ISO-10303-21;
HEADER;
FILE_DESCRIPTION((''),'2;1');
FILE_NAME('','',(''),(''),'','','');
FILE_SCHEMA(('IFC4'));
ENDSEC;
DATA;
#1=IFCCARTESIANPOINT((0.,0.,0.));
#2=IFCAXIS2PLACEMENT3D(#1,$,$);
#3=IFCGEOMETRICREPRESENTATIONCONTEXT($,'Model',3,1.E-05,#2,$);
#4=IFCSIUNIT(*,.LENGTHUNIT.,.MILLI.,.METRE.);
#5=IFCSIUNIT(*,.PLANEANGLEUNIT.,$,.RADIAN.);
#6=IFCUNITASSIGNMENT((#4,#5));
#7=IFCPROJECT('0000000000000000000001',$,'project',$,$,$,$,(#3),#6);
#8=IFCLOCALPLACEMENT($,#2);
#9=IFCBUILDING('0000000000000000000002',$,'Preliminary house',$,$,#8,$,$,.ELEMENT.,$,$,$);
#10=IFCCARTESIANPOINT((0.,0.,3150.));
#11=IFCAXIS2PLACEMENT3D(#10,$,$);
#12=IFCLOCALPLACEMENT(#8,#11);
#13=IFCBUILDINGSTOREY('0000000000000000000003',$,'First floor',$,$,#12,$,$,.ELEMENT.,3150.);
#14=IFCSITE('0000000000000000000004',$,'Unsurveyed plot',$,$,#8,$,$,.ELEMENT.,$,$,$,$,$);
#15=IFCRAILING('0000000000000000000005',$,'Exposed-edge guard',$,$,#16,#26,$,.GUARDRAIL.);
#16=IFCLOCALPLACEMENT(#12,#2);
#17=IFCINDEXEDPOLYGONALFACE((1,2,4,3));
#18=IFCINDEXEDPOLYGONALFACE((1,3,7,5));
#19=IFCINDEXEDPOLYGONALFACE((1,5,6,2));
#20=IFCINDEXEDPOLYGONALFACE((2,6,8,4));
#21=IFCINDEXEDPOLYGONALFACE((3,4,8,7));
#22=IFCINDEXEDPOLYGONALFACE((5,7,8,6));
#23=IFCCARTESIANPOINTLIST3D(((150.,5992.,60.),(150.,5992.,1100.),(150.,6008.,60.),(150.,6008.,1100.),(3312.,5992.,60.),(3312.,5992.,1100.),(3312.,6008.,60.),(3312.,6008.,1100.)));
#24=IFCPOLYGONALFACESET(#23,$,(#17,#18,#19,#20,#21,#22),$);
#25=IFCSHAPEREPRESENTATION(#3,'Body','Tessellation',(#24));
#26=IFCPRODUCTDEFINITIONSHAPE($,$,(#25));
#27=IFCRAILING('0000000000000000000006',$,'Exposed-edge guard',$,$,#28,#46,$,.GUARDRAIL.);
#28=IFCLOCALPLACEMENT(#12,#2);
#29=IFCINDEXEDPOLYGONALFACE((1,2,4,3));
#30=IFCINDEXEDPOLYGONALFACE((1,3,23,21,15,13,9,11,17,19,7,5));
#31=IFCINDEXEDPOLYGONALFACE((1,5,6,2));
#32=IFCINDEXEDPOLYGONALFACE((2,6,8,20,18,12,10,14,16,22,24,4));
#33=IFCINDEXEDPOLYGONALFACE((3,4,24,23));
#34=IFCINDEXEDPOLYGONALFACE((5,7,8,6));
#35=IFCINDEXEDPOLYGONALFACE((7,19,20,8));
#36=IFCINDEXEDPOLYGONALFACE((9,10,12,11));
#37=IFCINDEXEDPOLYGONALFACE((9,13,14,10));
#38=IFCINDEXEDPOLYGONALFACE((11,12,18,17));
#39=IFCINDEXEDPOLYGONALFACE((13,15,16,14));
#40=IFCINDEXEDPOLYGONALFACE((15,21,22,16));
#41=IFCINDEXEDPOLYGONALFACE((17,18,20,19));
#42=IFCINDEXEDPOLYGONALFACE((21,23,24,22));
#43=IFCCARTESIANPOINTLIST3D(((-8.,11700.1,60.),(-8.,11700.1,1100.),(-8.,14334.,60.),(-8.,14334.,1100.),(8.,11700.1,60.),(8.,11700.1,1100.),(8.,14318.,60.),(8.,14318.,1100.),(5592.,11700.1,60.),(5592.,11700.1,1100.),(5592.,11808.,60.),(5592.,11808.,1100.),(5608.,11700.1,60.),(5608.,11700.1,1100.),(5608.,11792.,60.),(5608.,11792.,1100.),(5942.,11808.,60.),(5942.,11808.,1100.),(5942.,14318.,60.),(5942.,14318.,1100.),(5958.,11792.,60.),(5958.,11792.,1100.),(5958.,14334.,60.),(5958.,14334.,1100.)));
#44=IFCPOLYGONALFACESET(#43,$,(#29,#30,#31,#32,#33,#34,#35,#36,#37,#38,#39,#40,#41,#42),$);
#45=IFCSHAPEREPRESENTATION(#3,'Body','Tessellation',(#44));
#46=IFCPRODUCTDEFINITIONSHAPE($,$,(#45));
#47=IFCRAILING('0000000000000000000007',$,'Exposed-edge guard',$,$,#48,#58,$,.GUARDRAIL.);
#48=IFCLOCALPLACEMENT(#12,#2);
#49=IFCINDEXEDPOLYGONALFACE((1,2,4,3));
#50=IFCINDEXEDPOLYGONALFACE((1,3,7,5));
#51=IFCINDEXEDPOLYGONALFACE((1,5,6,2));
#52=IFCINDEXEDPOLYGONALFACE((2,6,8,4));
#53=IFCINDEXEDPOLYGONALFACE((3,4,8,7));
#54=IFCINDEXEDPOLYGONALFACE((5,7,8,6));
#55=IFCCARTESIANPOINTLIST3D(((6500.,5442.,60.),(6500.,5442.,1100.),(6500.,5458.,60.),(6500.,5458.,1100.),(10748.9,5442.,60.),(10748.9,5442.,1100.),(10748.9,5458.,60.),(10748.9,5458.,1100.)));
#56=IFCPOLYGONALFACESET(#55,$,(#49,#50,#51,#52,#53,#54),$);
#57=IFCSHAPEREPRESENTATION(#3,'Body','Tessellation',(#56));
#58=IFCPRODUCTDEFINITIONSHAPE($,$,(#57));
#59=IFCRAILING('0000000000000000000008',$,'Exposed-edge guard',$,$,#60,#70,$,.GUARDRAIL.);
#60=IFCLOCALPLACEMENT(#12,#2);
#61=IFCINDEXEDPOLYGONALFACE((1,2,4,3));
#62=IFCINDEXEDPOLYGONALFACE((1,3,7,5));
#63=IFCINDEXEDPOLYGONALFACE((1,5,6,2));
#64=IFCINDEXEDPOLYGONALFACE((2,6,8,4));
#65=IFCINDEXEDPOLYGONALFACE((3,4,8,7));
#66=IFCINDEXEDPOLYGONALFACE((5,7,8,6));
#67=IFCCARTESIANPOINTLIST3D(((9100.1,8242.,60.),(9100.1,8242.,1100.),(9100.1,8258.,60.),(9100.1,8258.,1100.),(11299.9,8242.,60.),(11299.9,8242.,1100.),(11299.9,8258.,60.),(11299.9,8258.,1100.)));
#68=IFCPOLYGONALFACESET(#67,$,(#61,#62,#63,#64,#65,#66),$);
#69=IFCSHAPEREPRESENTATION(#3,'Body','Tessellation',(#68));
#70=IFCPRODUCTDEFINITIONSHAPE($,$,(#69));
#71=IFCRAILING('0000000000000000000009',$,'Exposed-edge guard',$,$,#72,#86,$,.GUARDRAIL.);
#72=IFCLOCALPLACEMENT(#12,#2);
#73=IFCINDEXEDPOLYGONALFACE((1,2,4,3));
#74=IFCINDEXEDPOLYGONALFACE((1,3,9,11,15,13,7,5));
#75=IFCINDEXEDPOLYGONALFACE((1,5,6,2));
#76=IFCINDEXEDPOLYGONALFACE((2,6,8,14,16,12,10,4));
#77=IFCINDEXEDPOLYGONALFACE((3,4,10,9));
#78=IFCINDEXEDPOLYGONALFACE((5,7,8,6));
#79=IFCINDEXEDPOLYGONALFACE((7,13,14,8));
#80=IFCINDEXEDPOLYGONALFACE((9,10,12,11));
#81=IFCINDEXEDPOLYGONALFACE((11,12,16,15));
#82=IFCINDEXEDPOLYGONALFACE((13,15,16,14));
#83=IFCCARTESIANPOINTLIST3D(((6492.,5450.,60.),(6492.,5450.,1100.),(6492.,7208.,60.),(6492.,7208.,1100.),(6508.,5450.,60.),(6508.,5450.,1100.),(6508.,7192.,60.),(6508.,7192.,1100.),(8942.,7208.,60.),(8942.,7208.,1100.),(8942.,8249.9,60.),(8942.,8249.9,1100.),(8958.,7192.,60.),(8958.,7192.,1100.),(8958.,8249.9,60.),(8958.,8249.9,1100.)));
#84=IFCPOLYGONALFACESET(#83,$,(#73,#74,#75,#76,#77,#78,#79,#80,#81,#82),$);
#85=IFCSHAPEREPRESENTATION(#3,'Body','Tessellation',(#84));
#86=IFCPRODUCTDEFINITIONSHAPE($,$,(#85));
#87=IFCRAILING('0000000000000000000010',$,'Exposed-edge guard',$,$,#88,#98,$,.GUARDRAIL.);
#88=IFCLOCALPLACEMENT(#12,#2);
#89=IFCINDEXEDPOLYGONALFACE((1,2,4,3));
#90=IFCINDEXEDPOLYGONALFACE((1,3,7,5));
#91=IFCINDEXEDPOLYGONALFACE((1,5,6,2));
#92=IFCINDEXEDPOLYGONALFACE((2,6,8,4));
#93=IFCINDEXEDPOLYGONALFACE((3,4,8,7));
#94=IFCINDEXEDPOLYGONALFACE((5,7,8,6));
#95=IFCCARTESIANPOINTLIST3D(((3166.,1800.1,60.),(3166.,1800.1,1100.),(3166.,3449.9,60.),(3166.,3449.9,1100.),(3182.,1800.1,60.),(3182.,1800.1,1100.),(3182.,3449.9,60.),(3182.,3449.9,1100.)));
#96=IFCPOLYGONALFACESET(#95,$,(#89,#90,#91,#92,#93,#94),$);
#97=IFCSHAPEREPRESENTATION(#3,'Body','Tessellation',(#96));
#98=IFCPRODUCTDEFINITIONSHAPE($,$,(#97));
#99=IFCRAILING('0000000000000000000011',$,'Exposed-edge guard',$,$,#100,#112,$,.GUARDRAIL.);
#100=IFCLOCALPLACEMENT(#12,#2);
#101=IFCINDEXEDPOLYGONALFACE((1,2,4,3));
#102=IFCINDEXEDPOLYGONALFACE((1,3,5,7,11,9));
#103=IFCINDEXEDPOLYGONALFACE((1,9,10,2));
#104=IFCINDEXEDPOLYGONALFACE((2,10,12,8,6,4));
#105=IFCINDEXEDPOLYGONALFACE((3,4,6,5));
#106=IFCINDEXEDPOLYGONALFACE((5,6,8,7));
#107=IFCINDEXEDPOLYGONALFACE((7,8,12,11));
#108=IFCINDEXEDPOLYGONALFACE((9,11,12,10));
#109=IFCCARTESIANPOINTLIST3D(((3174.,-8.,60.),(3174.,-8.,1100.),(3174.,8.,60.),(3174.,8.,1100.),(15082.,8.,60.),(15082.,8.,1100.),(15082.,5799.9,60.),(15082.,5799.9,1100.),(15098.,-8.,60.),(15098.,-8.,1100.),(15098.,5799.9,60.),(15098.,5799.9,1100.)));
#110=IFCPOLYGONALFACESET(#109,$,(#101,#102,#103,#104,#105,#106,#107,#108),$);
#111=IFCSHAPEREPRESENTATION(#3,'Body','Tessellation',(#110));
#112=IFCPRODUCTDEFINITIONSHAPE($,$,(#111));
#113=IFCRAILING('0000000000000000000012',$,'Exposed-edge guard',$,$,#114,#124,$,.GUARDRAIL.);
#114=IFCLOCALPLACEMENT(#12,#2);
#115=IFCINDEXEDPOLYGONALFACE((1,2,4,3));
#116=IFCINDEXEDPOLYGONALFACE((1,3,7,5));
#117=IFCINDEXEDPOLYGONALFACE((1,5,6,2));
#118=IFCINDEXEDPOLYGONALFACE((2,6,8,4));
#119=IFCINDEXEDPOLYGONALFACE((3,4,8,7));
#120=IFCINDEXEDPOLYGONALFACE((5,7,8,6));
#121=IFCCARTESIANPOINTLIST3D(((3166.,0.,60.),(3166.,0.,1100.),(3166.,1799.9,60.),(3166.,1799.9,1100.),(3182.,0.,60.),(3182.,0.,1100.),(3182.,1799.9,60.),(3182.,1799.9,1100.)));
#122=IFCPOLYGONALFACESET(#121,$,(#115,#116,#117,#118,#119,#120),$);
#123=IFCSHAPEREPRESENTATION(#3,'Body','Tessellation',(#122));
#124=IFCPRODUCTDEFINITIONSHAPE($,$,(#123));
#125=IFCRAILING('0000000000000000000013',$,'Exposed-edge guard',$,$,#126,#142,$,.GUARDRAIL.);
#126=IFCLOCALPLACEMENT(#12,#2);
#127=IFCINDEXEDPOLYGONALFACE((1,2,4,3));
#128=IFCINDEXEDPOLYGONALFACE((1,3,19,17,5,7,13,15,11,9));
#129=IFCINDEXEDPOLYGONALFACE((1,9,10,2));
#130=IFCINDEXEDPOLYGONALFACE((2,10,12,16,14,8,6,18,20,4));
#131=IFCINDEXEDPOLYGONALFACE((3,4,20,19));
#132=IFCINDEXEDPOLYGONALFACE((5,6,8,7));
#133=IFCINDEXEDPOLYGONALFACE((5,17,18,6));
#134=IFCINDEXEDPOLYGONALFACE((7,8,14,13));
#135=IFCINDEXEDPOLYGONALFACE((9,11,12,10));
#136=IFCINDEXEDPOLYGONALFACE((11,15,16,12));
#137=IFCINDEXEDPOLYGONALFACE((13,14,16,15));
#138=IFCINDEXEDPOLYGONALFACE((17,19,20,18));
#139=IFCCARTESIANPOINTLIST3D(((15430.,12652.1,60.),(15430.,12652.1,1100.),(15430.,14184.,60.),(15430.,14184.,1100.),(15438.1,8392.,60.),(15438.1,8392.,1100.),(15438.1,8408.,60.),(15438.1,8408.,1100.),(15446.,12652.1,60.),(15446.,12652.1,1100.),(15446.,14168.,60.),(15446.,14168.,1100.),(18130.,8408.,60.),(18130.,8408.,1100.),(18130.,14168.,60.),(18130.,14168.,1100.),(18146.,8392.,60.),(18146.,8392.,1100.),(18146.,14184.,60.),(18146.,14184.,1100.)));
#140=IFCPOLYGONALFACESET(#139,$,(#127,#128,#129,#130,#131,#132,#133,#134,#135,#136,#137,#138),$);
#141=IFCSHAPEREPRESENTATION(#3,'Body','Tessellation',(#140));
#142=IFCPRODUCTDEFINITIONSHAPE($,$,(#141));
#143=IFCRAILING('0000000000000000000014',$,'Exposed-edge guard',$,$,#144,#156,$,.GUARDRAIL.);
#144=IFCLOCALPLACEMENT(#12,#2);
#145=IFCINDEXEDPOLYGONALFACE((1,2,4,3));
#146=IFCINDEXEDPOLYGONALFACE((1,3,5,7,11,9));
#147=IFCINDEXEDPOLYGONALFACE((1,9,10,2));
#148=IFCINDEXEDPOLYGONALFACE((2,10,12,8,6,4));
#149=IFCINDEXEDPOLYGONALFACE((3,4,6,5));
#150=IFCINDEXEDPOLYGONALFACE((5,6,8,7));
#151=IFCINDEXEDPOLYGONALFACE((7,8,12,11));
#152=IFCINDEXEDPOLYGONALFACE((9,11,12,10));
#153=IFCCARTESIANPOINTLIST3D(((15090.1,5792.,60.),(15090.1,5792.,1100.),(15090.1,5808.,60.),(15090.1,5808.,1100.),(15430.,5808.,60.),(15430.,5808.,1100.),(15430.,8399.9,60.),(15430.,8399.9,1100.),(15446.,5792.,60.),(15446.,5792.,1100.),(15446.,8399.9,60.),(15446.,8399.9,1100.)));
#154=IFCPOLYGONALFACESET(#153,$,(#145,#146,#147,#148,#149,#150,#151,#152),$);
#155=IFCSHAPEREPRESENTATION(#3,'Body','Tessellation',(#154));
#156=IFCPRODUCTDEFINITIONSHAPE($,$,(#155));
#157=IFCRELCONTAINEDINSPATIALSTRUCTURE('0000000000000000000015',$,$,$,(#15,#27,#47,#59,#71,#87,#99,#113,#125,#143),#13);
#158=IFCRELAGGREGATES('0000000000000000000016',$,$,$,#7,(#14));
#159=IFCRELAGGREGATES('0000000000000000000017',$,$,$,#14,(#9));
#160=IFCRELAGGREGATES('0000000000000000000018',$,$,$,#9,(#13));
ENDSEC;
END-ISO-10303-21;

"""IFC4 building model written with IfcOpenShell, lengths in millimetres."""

from ifc_helpers import new_model, si_unit, frame, origin, place, context, project, spatial, polyline, outline, extrude, element, save


model = new_model("IFC4")

# Units and contexts
model_context = context("Model", 3, precision=1e-05, world=origin())
ifc_project = project(units=[si_unit("LENGTHUNIT", "METRE", prefix="MILLI"), si_unit("PLANEANGLEUNIT", "RADIAN")], contexts=[model_context])

# Site, building, storey
placement_1 = place(None, origin())
site = spatial("IfcSite", under=ifc_project, at=placement_1, Name="Unsurveyed plot", CompositionType="ELEMENT")
building = spatial("IfcBuilding", under=site, at=placement_1, Name="Preliminary house", CompositionType="ELEMENT")
placement_2 = place(placement_1, frame((0.0, 0.0, 3150.0)))
storey = spatial("IfcBuildingStorey", under=building, at=placement_2, Name="First floor", CompositionType="ELEMENT", Elevation=3150.0)

# Railings
element("IfcRailing", 1, at=placement_2, inside=storey, Name="Exposed-edge guard", PredefinedType="GUARDRAIL", context=model_context, shape_type="SweptSolid", body=[
    extrude(outline(polyline([(150.0, 5992.0), (150.0, 6008.0), (3312.0, 6008.0), (3312.0, 5992.0), (150.0, 5992.0)])), frame((0.0, 0.0, 60.0)), (0.0, 0.0, 1.0), 1040.0),
])
element("IfcRailing", 2, at=placement_2, inside=storey, Name="Exposed-edge guard", PredefinedType="GUARDRAIL", context=model_context, shape_type="SweptSolid", body=[
    extrude(outline(polyline([(5592.0, 11808.0), (5942.0, 11808.0), (5942.0, 14318.0), (8.0, 14318.0), (8.0, 11700.1), (-8.0, 11700.1), (-8.0, 14334.0), (5958.0, 14334.0), (5958.0, 11792.0), (5608.0, 11792.0), (5608.0, 11700.1), (5592.0, 11700.1), (5592.0, 11808.0)])), frame((0.0, 0.0, 60.0)), (0.0, 0.0, 1.0), 1040.0),
])
element("IfcRailing", 3, at=placement_2, inside=storey, Name="Exposed-edge guard", PredefinedType="GUARDRAIL", context=model_context, shape_type="SweptSolid", body=[
    extrude(outline(polyline([(10748.9, 5458.0), (10748.9, 5442.0), (6500.0, 5442.0), (6500.0, 5458.0), (10748.9, 5458.0)])), frame((0.0, 0.0, 60.0)), (0.0, 0.0, 1.0), 1040.0),
])
element("IfcRailing", 4, at=placement_2, inside=storey, Name="Exposed-edge guard", PredefinedType="GUARDRAIL", context=model_context, shape_type="SweptSolid", body=[
    extrude(outline(polyline([(9100.1, 8242.0), (9100.1, 8258.0), (11299.9, 8258.0), (11299.9, 8242.0), (9100.1, 8242.0)])), frame((0.0, 0.0, 60.0)), (0.0, 0.0, 1.0), 1040.0),
])
element("IfcRailing", 5, at=placement_2, inside=storey, Name="Exposed-edge guard", PredefinedType="GUARDRAIL", context=model_context, shape_type="SweptSolid", body=[
    extrude(outline(polyline([(8958.0, 7192.0), (6508.0, 7192.0), (6508.0, 5450.0), (6492.0, 5450.0), (6492.0, 7208.0), (8942.0, 7208.0), (8942.0, 8249.9), (8958.0, 8249.9), (8958.0, 7192.0)])), frame((0.0, 0.0, 60.0)), (0.0, 0.0, 1.0), 1040.0),
])
element("IfcRailing", 6, at=placement_2, inside=storey, Name="Exposed-edge guard", PredefinedType="GUARDRAIL", context=model_context, shape_type="SweptSolid", body=[
    extrude(outline(polyline([(3182.0, 1800.1), (3166.0, 1800.1), (3166.0, 3449.9), (3182.0, 3449.9), (3182.0, 1800.1)])), frame((0.0, 0.0, 60.0)), (0.0, 0.0, 1.0), 1040.0),
])
element("IfcRailing", 7, at=placement_2, inside=storey, Name="Exposed-edge guard", PredefinedType="GUARDRAIL", context=model_context, shape_type="SweptSolid", body=[
    extrude(outline(polyline([(15082.0, 8.0), (15082.0, 5799.9), (15098.0, 5799.9), (15098.0, -8.0), (3174.0, -8.0), (3174.0, 8.0), (15082.0, 8.0)])), frame((0.0, 0.0, 60.0)), (0.0, 0.0, 1.0), 1040.0),
])
element("IfcRailing", 8, at=placement_2, inside=storey, Name="Exposed-edge guard", PredefinedType="GUARDRAIL", context=model_context, shape_type="SweptSolid", body=[
    extrude(outline(polyline([(3182.0, 0.0), (3166.0, 0.0), (3166.0, 1799.9), (3182.0, 1799.9), (3182.0, 0.0)])), frame((0.0, 0.0, 60.0)), (0.0, 0.0, 1.0), 1040.0),
])
element("IfcRailing", 9, at=placement_2, inside=storey, Name="Exposed-edge guard", PredefinedType="GUARDRAIL", context=model_context, shape_type="SweptSolid", body=[
    extrude(outline(polyline([(18130.0, 8408.0), (18130.0, 14168.0), (15446.0, 14168.0), (15446.0, 12652.1), (15430.0, 12652.1), (15430.0, 14184.0), (18146.0, 14184.0), (18146.0, 8392.0), (15438.1, 8392.0), (15438.1, 8408.0), (18130.0, 8408.0)])), frame((0.0, 0.0, 60.0)), (0.0, 0.0, 1.0), 1040.0),
])
element("IfcRailing", 10, at=placement_2, inside=storey, Name="Exposed-edge guard", PredefinedType="GUARDRAIL", context=model_context, shape_type="SweptSolid", body=[
    extrude(outline(polyline([(15430.0, 5808.0), (15430.0, 8399.9), (15446.0, 8399.9), (15446.0, 5792.0), (15090.1, 5792.0), (15090.1, 5808.0), (15430.0, 5808.0)])), frame((0.0, 0.0, 60.0)), (0.0, 0.0, 1.0), 1040.0),
])

save(model, "model.ifc")
